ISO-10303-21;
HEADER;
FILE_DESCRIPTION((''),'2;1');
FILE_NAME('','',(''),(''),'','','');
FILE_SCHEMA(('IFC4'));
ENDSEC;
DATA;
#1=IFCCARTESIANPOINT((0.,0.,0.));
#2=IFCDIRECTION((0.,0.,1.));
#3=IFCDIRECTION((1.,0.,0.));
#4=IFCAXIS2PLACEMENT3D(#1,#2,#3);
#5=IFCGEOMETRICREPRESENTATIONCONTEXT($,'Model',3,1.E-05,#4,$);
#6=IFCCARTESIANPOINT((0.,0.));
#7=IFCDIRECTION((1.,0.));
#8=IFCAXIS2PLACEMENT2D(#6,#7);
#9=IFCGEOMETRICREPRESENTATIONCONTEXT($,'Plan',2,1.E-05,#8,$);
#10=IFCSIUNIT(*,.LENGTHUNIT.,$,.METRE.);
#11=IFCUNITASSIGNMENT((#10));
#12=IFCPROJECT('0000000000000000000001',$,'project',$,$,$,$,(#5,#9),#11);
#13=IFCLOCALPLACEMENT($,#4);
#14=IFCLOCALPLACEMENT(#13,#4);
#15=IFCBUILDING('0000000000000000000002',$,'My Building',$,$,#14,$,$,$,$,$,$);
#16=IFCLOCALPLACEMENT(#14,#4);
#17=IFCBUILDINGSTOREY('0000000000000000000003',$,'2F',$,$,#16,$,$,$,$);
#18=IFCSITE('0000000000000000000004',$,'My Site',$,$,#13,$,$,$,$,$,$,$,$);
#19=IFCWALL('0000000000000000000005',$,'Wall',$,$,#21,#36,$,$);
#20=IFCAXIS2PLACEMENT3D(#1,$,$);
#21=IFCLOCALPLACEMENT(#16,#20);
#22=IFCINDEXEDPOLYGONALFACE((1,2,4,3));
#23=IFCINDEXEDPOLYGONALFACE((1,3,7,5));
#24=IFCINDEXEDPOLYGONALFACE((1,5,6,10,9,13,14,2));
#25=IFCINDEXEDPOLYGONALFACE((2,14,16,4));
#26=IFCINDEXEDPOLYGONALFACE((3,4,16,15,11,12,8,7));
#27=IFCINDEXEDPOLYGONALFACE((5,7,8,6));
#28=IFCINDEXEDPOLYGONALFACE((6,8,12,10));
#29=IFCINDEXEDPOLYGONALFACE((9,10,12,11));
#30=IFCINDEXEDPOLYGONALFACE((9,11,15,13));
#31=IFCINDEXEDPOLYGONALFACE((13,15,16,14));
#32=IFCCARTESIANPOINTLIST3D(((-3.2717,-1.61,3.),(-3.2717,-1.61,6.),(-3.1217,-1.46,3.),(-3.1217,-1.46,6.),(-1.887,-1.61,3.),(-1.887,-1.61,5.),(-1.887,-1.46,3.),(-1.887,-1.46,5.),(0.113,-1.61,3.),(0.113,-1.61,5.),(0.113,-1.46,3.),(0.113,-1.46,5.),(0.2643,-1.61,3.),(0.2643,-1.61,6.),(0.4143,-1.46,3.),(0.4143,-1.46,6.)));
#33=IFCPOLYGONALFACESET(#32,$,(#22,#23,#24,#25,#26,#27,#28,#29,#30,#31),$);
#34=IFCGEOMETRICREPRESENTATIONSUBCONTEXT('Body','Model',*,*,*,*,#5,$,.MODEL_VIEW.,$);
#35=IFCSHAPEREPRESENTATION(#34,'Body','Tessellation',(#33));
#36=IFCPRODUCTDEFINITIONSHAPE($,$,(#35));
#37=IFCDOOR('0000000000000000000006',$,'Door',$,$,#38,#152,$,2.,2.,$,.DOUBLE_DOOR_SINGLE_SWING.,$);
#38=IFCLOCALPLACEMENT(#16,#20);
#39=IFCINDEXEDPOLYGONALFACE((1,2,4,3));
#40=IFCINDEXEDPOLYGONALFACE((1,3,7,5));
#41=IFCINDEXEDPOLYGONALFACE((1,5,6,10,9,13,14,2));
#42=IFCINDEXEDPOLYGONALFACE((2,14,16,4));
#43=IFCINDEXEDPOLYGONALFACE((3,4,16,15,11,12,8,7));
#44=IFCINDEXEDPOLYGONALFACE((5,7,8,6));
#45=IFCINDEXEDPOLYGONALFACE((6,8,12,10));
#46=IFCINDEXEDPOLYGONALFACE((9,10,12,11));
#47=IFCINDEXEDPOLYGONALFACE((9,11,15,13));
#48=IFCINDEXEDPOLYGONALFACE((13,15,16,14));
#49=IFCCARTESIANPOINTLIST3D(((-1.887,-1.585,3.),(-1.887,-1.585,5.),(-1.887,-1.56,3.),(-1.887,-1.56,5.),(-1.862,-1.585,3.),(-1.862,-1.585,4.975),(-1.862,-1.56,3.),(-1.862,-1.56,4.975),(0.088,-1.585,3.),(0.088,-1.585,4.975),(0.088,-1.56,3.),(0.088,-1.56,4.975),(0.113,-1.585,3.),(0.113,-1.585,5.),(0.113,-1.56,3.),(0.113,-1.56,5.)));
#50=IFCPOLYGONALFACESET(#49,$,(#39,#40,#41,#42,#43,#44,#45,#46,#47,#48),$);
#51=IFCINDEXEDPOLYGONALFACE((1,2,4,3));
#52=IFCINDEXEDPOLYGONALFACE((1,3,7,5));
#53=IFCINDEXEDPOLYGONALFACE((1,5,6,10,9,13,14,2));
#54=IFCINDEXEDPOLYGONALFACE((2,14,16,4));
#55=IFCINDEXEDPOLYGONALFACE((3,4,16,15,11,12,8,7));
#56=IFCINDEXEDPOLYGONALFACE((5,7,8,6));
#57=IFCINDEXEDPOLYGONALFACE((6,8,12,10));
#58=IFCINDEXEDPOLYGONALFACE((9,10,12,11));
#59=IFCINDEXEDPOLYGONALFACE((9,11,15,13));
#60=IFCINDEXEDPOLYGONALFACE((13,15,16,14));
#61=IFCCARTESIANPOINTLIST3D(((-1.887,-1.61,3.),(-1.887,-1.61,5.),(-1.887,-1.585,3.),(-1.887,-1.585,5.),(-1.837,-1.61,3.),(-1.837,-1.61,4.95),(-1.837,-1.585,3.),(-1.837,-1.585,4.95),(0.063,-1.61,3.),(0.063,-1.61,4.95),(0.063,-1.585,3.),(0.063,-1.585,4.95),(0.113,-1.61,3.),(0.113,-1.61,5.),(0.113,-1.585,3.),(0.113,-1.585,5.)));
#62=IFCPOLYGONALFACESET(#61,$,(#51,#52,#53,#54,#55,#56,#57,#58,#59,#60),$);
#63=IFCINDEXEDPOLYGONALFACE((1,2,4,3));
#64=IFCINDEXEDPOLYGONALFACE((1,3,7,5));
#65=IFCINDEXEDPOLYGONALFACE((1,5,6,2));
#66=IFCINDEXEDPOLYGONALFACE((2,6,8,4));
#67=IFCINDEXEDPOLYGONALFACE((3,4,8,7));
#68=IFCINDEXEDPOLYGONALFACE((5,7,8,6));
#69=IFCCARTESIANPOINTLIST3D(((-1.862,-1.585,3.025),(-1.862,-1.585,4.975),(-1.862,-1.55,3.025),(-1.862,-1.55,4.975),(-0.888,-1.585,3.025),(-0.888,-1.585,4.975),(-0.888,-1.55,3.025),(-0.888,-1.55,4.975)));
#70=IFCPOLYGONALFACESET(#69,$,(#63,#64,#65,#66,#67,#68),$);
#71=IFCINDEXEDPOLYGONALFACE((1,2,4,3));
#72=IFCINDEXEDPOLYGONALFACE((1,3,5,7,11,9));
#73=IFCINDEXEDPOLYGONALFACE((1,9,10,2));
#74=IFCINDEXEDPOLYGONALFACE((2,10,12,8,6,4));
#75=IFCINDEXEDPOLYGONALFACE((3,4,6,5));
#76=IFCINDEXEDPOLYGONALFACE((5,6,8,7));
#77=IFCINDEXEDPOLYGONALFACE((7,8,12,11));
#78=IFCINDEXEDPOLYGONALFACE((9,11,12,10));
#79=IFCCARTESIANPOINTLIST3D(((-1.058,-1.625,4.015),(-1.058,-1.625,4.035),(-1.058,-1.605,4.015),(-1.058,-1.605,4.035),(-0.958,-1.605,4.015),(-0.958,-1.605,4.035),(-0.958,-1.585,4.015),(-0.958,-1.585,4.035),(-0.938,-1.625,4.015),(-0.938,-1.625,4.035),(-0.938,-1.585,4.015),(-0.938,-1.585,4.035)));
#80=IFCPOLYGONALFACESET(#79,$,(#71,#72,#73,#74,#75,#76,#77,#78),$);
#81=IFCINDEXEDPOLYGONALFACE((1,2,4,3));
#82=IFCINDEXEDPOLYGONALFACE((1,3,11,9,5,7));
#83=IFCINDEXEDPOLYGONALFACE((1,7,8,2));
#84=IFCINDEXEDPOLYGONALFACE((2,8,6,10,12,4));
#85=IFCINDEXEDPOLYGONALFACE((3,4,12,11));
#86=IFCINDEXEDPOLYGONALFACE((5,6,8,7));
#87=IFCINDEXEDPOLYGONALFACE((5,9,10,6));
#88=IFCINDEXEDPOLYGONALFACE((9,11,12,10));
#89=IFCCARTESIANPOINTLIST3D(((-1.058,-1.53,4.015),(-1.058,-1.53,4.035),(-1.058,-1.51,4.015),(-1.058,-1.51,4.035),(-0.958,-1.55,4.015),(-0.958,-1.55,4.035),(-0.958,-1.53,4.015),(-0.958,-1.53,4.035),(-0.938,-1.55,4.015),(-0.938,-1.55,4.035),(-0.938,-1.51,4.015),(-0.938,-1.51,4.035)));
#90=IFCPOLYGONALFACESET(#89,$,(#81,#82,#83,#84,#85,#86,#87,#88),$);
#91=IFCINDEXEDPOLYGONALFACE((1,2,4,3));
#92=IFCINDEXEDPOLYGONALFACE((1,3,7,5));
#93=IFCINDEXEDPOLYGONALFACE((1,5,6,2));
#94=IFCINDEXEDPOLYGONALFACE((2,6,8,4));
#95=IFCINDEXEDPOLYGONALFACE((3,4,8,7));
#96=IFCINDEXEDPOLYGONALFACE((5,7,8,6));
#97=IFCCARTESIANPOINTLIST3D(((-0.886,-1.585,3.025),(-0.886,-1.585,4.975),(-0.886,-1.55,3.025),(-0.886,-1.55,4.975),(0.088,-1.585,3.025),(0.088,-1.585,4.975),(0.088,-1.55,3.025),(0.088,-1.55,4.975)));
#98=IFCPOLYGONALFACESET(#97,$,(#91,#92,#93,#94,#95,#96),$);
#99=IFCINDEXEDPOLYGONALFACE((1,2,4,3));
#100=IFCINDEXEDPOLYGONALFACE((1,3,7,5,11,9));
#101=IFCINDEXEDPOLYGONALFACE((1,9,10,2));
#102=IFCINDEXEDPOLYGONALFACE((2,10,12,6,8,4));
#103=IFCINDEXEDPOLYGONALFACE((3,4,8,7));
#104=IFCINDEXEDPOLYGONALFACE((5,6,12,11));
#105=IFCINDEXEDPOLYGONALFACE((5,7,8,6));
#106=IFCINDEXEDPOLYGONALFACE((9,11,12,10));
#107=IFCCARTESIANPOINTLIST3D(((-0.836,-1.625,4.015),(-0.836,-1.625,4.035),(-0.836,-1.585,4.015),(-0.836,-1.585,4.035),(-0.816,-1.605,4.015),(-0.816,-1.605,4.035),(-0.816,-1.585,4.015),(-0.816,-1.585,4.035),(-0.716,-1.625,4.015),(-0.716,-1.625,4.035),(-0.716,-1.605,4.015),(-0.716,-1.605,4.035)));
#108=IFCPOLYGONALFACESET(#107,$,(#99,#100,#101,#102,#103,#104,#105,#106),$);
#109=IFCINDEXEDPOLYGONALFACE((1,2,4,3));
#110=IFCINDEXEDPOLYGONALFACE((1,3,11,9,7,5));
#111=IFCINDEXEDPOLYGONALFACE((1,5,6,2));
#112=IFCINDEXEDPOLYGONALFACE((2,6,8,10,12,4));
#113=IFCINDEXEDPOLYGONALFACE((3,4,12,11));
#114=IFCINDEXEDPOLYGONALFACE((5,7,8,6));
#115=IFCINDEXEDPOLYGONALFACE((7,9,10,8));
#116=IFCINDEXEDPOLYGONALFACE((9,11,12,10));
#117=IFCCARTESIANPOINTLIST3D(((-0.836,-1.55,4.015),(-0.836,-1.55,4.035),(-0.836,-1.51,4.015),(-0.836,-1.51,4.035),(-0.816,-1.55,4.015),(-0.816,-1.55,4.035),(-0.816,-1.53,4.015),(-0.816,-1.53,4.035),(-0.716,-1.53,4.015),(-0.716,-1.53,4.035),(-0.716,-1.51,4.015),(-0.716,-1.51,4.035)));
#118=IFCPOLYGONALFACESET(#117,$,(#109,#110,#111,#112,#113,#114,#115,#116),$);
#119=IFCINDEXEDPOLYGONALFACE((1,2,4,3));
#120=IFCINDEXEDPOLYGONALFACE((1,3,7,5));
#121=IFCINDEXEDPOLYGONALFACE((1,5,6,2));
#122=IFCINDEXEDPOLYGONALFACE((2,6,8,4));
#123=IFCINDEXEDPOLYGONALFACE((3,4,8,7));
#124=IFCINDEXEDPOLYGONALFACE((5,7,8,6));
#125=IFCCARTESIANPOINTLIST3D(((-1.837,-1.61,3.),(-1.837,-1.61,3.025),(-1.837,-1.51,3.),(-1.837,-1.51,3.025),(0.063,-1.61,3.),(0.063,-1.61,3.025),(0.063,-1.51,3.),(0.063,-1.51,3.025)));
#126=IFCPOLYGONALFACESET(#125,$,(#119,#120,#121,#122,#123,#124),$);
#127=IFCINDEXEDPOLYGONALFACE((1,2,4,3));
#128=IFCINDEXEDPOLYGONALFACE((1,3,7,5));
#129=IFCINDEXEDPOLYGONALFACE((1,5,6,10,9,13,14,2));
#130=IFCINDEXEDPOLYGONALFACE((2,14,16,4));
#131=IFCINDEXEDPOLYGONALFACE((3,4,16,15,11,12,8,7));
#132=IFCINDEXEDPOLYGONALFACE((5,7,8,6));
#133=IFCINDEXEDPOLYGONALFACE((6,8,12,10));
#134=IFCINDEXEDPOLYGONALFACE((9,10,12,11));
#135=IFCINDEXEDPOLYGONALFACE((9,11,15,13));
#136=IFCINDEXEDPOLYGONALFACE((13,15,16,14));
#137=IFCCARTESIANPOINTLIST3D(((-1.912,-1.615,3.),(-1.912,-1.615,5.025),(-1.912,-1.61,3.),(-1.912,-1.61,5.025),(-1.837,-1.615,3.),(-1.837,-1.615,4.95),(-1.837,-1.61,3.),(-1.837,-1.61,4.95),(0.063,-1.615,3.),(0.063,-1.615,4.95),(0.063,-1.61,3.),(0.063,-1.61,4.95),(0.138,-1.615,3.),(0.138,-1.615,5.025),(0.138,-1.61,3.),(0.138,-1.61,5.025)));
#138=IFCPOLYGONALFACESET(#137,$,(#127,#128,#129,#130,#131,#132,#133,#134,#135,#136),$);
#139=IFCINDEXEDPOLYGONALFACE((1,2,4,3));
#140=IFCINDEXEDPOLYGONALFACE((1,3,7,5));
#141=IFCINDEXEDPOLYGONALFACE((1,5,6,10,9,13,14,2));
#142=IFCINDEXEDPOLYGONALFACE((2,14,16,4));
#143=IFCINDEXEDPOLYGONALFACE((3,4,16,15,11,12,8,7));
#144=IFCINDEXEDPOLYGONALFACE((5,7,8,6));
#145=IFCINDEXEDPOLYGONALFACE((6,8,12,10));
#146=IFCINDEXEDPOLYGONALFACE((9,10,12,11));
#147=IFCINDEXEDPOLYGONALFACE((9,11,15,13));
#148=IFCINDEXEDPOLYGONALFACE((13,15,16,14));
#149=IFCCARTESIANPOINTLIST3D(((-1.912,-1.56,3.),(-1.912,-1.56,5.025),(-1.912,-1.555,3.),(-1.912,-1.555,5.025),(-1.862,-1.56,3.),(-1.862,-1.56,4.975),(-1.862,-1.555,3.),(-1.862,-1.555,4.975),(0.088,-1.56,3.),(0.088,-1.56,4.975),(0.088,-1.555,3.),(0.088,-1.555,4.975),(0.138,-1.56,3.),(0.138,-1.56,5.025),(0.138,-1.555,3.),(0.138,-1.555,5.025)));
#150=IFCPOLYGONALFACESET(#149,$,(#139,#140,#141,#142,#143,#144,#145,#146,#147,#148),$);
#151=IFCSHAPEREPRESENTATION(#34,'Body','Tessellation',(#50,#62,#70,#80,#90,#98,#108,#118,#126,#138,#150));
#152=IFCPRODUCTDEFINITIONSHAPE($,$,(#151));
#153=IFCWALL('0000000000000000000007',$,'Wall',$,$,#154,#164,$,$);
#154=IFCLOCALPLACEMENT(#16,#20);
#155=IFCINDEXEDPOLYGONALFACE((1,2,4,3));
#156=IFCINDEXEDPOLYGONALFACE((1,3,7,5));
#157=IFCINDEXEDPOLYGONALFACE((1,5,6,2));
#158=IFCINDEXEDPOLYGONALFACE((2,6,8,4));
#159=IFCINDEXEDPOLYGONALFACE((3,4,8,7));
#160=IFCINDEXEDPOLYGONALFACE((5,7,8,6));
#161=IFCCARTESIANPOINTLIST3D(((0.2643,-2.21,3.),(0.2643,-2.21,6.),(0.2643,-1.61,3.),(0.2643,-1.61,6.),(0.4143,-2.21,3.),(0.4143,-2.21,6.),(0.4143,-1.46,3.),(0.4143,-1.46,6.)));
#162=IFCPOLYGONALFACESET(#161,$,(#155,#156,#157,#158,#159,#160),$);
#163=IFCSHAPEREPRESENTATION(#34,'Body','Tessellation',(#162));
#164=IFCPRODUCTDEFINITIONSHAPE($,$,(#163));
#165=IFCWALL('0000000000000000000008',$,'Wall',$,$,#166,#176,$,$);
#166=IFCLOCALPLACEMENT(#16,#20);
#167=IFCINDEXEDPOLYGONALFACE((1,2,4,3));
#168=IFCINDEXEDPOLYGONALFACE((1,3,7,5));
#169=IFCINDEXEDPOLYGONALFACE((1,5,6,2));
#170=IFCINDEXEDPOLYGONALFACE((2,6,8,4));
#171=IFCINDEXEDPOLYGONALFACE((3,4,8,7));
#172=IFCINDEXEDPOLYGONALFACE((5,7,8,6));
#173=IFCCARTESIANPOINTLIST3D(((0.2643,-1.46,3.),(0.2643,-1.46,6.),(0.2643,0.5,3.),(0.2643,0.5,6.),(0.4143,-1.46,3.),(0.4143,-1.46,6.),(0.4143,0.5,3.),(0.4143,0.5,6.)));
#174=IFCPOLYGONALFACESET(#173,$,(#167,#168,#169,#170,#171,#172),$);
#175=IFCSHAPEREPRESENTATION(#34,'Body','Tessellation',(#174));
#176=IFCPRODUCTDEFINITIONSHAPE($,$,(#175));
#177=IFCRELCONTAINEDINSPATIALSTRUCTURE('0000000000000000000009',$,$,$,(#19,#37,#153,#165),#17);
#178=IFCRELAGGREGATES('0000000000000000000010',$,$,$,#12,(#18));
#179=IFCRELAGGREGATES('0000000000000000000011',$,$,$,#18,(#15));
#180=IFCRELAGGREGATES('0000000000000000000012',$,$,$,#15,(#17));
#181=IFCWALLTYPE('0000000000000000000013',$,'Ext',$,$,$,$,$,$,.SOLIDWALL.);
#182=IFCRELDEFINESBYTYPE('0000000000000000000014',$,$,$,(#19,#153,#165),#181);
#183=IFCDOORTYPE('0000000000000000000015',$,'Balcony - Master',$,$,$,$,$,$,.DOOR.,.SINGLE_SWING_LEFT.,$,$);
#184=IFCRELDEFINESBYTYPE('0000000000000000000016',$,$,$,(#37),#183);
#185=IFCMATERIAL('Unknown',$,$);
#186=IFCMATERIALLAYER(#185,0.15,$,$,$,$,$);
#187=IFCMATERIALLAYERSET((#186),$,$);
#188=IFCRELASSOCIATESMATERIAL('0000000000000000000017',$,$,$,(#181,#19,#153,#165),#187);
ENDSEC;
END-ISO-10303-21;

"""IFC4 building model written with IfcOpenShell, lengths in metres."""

from ifc_helpers import new_model, entity, si_unit, frame, origin_with_axes, origin_2d_with_axis, place, context, subcontext, project, spatial, line, indexed_curve, outline, extrude, shape, source, transform, mapped, material, layer, layer_set, layer_usage, type_object, type_shapes, element, fill, save


model = new_model("IFC4")

# Units and contexts
model_context = context("Model", 3, precision=1e-05, world=origin_with_axes())
plan_context = context("Plan", 2, precision=1e-05, world=origin_2d_with_axis())
body_context_1 = subcontext(model_context, "Body", "Model", "MODEL_VIEW")
body_context_2 = subcontext(plan_context, "Body", "Plan", "PLAN_VIEW")
ifc_project = project(units=[si_unit("LENGTHUNIT", "METRE")], contexts=[model_context, plan_context])

# Site, building, storey
site_placement = place(None, origin_with_axes())
site = spatial("IfcSite", under=ifc_project, at=site_placement, Name="My Site")
building_placement = place(site_placement, origin_with_axes())
building = spatial("IfcBuilding", under=site, at=building_placement, Name="My Building")
storey_placement = place(building_placement, origin_with_axes())
storey = spatial("IfcBuildingStorey", under=building, at=storey_placement, Name="2F")

# Shared definitions
ifc_material = material(Name="Unknown")
ifc_layer_1 = layer(ifc_material, 0.15)
ifc_layer_set_1 = layer_set([ifc_layer_1])
wall_type_1 = type_object("IfcWallType", Name="Ext", PredefinedType="SOLIDWALL", material=ifc_layer_set_1)

# Wall, opening, door
ifc_layer_usage_1 = layer_usage(ifc_layer_set_1, "AXIS2", "POSITIVE", 0.0)
wall_1_placement = place(storey_placement, frame((-3.2717, -1.61, 3.0), z_axis=(0.0, 0.0, 1.0), x_axis=(1.0, 0.0, 0.0)))
wall_1 = element("IfcWall", 1, at=wall_1_placement, inside=storey, type_object=wall_type_1, material=ifc_layer_usage_1, Name="Wall", context=body_context_1, shape_type="SweptSolid", body=[
    extrude(outline(indexed_curve([(0.0, 0.0), (0.15, 0.15), (3.686, 0.15), (3.536, 0.0)], segments=[line(1, 2, 3, 4, 1)])), origin_with_axes(), (0.0, 0.0, 1.0), 3.0),
])
shared_shape_1 = source(origin_with_axes(), body_context_1, "Body", "SweptSolid", [
    extrude(outline(indexed_curve([(0.0, 0.0), (2.0, 0.0), (2.0, 2.0), (0.0, 2.0)], segments=[line(1, 2, 3, 4, 1)])), frame((0.0, -0.6, 0.0), z_axis=(0.0, -1.0, 0.0), x_axis=(1.0, 0.0, 0.0)), (0.0, 0.0, -1.0), 1.2),
])
opening_1_placement = place(wall_1_placement, frame((1.3847, 0.0, 0.0), z_axis=(0.0, 0.0, 1.0), x_axis=(1.0, 0.0, 0.0)))
opening_1 = element("IfcOpeningElement", 2, at=opening_1_placement, cuts=wall_1, PredefinedType="OPENING", context=body_context_1, shape_type="MappedRepresentation", body=[
    mapped(shared_shape_1, transform((0.0, 0.0, 0.0), x_axis=(1.0, 0.0, 0.0), y_axis=(0.0, 1.0, 0.0), z_axis=(0.0, 0.0, 1.0), scale=1.0)),
])
door_type_1 = type_object("IfcDoorType", Name="Balcony - Master", OperationType="SINGLE_SWING_LEFT", PredefinedType="DOOR")
shared_shape_2 = source(origin_with_axes(), body_context_1, "Body", "SweptSolid", [
    extrude(outline(indexed_curve([(0.0, 0.0), (0.0, 2.0), (2.0, 2.0), (2.0, 0.0), (1.975, 0.0), (1.975, 1.975), (0.025, 1.975), (0.025, 0.0)], segments=[line(1, 2, 3, 4, 5, 6, 7, 8, 1)])), frame((0.0, 0.025, 0.0), z_axis=(0.0, -1.0, 0.0), x_axis=(1.0, 0.0, 0.0)), (0.0, 0.0, -1.0), 0.025),
    extrude(outline(indexed_curve([(0.0, 0.0), (0.0, 2.0), (2.0, 2.0), (2.0, 0.0), (1.95, 0.0), (1.95, 1.95), (0.05, 1.95), (0.05, 0.0)], segments=[line(1, 2, 3, 4, 5, 6, 7, 8, 1)])), frame((0.0, 0.0, 0.0), z_axis=(0.0, -1.0, 0.0), x_axis=(1.0, 0.0, 0.0)), (0.0, 0.0, -1.0), 0.025),
    extrude(outline(indexed_curve([(0.0, 0.0), (0.974, 0.0), (0.974, 0.035), (0.0, 0.035)], segments=[line(1, 2, 3, 4, 1)])), frame((0.025, 0.025, 0.025), z_axis=(0.0, 0.0, 1.0), x_axis=(1.0, 0.0, 0.0)), (0.0, 0.0, 1.0), 1.95),
    extrude(outline(indexed_curve([(0.0, 0.0), (0.0, -0.04), (-0.12, -0.04), (-0.12, -0.02), (-0.02, -0.02), (-0.02, 0.0)], segments=[line(1, 2, 3, 4, 5, 6, 1)])), frame((0.949, 0.025, 1.015), z_axis=(0.0, 0.0, 1.0), x_axis=(1.0, 0.0, 0.0)), (0.0, 0.0, 1.0), 0.02),
    extrude(outline(indexed_curve([(0.0, 0.0), (0.0, 0.04), (-0.12, 0.04), (-0.12, 0.02), (-0.02, 0.02), (-0.02, 0.0)], segments=[line(1, 2, 3, 4, 5, 6, 1)])), frame((0.949, 0.06, 1.015), z_axis=(0.0, 0.0, 1.0), x_axis=(1.0, 0.0, 0.0)), (0.0, 0.0, 1.0), 0.02),
    extrude(outline(indexed_curve([(0.0, 0.0), (-0.974, 0.0), (-0.974, 0.035), (0.0, 0.035)], segments=[line(1, 2, 3, 4, 1)])), frame((1.975, 0.025, 0.025), z_axis=(0.0, 0.0, 1.0), x_axis=(1.0, 0.0, 0.0)), (0.0, 0.0, 1.0), 1.95),
    extrude(outline(indexed_curve([(0.0, 0.0), (0.0, -0.04), (0.12, -0.04), (0.12, -0.02), (0.02, -0.02), (0.02, 0.0)], segments=[line(1, 2, 3, 4, 5, 6, 1)])), frame((1.051, 0.025, 1.015), z_axis=(0.0, 0.0, 1.0), x_axis=(1.0, 0.0, 0.0)), (0.0, 0.0, 1.0), 0.02),
    extrude(outline(indexed_curve([(0.0, 0.0), (0.0, 0.04), (0.12, 0.04), (0.12, 0.02), (0.02, 0.02), (0.02, 0.0)], segments=[line(1, 2, 3, 4, 5, 6, 1)])), frame((1.051, 0.06, 1.015), z_axis=(0.0, 0.0, 1.0), x_axis=(1.0, 0.0, 0.0)), (0.0, 0.0, 1.0), 0.02),
    extrude(outline(indexed_curve([(0.0, 0.0), (1.9, 0.0), (1.9, 0.1), (0.0, 0.1)], segments=[line(1, 2, 3, 4, 1)])), frame((0.05, 0.0, 0.0), z_axis=(0.0, 0.0, 1.0), x_axis=(1.0, 0.0, 0.0)), (0.0, 0.0, 1.0), 0.025),
    extrude(outline(indexed_curve([(0.0, 0.0), (0.0, 2.025), (2.05, 2.025), (2.05, 0.0), (1.975, 0.0), (1.975, 1.95), (0.075, 1.95), (0.075, 0.0)], segments=[line(1, 2, 3, 4, 5, 6, 7, 8, 1)])), frame((-0.025, -0.005, 0.0), z_axis=(0.0, -1.0, 0.0), x_axis=(1.0, 0.0, 0.0)), (0.0, 0.0, -1.0), 0.005),
    extrude(outline(indexed_curve([(0.0, 0.0), (0.0, 2.025), (2.05, 2.025), (2.05, 0.0), (2.0, 0.0), (2.0, 1.975), (0.05, 1.975), (0.05, 0.0)], segments=[line(1, 2, 3, 4, 5, 6, 7, 8, 1)])), frame((-0.025, 0.05, 0.0), z_axis=(0.0, -1.0, 0.0), x_axis=(1.0, 0.0, 0.0)), (0.0, 0.0, -1.0), 0.005),
])
shared_shape_3 = source(origin_with_axes(), body_context_2, "Body", "Curve2D", [
    entity("IfcIndexedPolyCurve", entity("IfcCartesianPointList2D", [[0.0, 0.0], [0.0, 0.05], [0.025, 0.05], [0.025, 0.025], [0.05, 0.025], [0.05, 0.0]]), [entity("IfcLineIndex", [1, 2, 3, 4, 5, 6, 1])]),
    entity("IfcIndexedPolyCurve", entity("IfcCartesianPointList2D", [[2.0, 0.0], [2.0, 0.05], [1.975, 0.05], [1.975, 0.025], [1.95, 0.025], [1.95, 0.0]]), [entity("IfcLineIndex", [1, 2, 3, 4, 5, 6, 1])]),
    entity("IfcTrimmedCurve", entity("IfcEllipse", entity("IfcAxis2Placement2D", entity("IfcCartesianPoint", [0.06, 0.05]), entity("IfcDirection", [1.0, 0.0])), 0.94, 0.975), [entity("IfcCartesianPoint", [1.0, 0.05])], [entity("IfcCartesianPoint", [0.06, 1.025])], True, "CARTESIAN"),
    entity("IfcIndexedPolyCurve", entity("IfcCartesianPointList2D", [[0.025, 0.05], [0.06, 0.05], [0.06, 1.025], [0.025, 1.025]]), [entity("IfcLineIndex", [1, 2, 3, 4, 1])]),
    entity("IfcTrimmedCurve", entity("IfcEllipse", entity("IfcAxis2Placement2D", entity("IfcCartesianPoint", [1.94, 0.05]), entity("IfcDirection", [1.0, 0.0])), 0.94, 0.975), [entity("IfcCartesianPoint", [1.94, 1.025])], [entity("IfcCartesianPoint", [1.0, 0.05])], True, "CARTESIAN"),
    entity("IfcIndexedPolyCurve", entity("IfcCartesianPointList2D", [[1.975, 0.05], [1.94, 0.05], [1.94, 1.025], [1.975, 1.025]]), [entity("IfcLineIndex", [1, 2, 3, 4, 1])]),
])
type_shapes(door_type_1, [shared_shape_2, shared_shape_3])
door_1_placement = place(opening_1_placement, frame((0.0, 0.0, 0.0), z_axis=(0.0, 0.0, 1.0), x_axis=(1.0, 0.0, 0.0)))
door_1 = element("IfcDoor", 3, at=door_1_placement, inside=storey, type_object=door_type_1, Name="Door", OperationType="DOUBLE_DOOR_SINGLE_SWING", OverallHeight=2.0, OverallWidth=2.0, shapes=[
    shape(body_context_1, "Body", "MappedRepresentation", [mapped(shared_shape_2, transform((0.0, 0.0, 0.0), x_axis=(1.0, 0.0, 0.0), y_axis=(0.0, 1.0, 0.0), z_axis=(0.0, 0.0, 1.0), scale=1.0))]),
    shape(body_context_2, "Body", "MappedRepresentation", [mapped(shared_shape_3, transform((0.0, 0.0, 0.0), x_axis=(1.0, 0.0, 0.0), y_axis=(0.0, 1.0, 0.0), z_axis=(0.0, 0.0, 1.0), scale=1.0))]),
])
fill(opening_1, door_1)

# Walls
ifc_layer_usage_2 = layer_usage(ifc_layer_set_1, "AXIS2", "POSITIVE", 0.0)
wall_2_placement = place(storey_placement, frame((0.2643, -1.61, 3.0), z_axis=(0.0, 0.0, 1.0), x_axis=(0.0, -1.0, 0.0)))
element("IfcWall", 4, at=wall_2_placement, inside=storey, type_object=wall_type_1, material=ifc_layer_usage_2, Name="Wall", context=body_context_1, shape_type="SweptSolid", body=[
    extrude(outline(indexed_curve([(0.0, 0.0), (-0.15, 0.15), (0.6, 0.15), (0.6, 0.0)], segments=[line(1, 2, 3, 4, 1)])), origin_with_axes(), (0.0, 0.0, 1.0), 3.0),
])
ifc_layer_usage_3 = layer_usage(ifc_layer_set_1, "AXIS2", "POSITIVE", 0.0)
wall_3_placement = place(storey_placement, frame((0.4143, -1.46, 3.0), z_axis=(0.0, 0.0, 1.0), x_axis=(0.0, 1.0, 0.0)))
element("IfcWall", 5, at=wall_3_placement, inside=storey, type_object=wall_type_1, material=ifc_layer_usage_3, Name="Wall", context=body_context_1, shape_type="SweptSolid", body=[
    extrude(outline(indexed_curve([(0.0, 0.0), (0.0, 0.15), (1.96, 0.15), (1.96, 0.0)], segments=[line(1, 2, 3, 4, 1)])), origin_with_axes(), (0.0, 0.0, 1.0), 3.0),
])

save(model, "model.ifc")
